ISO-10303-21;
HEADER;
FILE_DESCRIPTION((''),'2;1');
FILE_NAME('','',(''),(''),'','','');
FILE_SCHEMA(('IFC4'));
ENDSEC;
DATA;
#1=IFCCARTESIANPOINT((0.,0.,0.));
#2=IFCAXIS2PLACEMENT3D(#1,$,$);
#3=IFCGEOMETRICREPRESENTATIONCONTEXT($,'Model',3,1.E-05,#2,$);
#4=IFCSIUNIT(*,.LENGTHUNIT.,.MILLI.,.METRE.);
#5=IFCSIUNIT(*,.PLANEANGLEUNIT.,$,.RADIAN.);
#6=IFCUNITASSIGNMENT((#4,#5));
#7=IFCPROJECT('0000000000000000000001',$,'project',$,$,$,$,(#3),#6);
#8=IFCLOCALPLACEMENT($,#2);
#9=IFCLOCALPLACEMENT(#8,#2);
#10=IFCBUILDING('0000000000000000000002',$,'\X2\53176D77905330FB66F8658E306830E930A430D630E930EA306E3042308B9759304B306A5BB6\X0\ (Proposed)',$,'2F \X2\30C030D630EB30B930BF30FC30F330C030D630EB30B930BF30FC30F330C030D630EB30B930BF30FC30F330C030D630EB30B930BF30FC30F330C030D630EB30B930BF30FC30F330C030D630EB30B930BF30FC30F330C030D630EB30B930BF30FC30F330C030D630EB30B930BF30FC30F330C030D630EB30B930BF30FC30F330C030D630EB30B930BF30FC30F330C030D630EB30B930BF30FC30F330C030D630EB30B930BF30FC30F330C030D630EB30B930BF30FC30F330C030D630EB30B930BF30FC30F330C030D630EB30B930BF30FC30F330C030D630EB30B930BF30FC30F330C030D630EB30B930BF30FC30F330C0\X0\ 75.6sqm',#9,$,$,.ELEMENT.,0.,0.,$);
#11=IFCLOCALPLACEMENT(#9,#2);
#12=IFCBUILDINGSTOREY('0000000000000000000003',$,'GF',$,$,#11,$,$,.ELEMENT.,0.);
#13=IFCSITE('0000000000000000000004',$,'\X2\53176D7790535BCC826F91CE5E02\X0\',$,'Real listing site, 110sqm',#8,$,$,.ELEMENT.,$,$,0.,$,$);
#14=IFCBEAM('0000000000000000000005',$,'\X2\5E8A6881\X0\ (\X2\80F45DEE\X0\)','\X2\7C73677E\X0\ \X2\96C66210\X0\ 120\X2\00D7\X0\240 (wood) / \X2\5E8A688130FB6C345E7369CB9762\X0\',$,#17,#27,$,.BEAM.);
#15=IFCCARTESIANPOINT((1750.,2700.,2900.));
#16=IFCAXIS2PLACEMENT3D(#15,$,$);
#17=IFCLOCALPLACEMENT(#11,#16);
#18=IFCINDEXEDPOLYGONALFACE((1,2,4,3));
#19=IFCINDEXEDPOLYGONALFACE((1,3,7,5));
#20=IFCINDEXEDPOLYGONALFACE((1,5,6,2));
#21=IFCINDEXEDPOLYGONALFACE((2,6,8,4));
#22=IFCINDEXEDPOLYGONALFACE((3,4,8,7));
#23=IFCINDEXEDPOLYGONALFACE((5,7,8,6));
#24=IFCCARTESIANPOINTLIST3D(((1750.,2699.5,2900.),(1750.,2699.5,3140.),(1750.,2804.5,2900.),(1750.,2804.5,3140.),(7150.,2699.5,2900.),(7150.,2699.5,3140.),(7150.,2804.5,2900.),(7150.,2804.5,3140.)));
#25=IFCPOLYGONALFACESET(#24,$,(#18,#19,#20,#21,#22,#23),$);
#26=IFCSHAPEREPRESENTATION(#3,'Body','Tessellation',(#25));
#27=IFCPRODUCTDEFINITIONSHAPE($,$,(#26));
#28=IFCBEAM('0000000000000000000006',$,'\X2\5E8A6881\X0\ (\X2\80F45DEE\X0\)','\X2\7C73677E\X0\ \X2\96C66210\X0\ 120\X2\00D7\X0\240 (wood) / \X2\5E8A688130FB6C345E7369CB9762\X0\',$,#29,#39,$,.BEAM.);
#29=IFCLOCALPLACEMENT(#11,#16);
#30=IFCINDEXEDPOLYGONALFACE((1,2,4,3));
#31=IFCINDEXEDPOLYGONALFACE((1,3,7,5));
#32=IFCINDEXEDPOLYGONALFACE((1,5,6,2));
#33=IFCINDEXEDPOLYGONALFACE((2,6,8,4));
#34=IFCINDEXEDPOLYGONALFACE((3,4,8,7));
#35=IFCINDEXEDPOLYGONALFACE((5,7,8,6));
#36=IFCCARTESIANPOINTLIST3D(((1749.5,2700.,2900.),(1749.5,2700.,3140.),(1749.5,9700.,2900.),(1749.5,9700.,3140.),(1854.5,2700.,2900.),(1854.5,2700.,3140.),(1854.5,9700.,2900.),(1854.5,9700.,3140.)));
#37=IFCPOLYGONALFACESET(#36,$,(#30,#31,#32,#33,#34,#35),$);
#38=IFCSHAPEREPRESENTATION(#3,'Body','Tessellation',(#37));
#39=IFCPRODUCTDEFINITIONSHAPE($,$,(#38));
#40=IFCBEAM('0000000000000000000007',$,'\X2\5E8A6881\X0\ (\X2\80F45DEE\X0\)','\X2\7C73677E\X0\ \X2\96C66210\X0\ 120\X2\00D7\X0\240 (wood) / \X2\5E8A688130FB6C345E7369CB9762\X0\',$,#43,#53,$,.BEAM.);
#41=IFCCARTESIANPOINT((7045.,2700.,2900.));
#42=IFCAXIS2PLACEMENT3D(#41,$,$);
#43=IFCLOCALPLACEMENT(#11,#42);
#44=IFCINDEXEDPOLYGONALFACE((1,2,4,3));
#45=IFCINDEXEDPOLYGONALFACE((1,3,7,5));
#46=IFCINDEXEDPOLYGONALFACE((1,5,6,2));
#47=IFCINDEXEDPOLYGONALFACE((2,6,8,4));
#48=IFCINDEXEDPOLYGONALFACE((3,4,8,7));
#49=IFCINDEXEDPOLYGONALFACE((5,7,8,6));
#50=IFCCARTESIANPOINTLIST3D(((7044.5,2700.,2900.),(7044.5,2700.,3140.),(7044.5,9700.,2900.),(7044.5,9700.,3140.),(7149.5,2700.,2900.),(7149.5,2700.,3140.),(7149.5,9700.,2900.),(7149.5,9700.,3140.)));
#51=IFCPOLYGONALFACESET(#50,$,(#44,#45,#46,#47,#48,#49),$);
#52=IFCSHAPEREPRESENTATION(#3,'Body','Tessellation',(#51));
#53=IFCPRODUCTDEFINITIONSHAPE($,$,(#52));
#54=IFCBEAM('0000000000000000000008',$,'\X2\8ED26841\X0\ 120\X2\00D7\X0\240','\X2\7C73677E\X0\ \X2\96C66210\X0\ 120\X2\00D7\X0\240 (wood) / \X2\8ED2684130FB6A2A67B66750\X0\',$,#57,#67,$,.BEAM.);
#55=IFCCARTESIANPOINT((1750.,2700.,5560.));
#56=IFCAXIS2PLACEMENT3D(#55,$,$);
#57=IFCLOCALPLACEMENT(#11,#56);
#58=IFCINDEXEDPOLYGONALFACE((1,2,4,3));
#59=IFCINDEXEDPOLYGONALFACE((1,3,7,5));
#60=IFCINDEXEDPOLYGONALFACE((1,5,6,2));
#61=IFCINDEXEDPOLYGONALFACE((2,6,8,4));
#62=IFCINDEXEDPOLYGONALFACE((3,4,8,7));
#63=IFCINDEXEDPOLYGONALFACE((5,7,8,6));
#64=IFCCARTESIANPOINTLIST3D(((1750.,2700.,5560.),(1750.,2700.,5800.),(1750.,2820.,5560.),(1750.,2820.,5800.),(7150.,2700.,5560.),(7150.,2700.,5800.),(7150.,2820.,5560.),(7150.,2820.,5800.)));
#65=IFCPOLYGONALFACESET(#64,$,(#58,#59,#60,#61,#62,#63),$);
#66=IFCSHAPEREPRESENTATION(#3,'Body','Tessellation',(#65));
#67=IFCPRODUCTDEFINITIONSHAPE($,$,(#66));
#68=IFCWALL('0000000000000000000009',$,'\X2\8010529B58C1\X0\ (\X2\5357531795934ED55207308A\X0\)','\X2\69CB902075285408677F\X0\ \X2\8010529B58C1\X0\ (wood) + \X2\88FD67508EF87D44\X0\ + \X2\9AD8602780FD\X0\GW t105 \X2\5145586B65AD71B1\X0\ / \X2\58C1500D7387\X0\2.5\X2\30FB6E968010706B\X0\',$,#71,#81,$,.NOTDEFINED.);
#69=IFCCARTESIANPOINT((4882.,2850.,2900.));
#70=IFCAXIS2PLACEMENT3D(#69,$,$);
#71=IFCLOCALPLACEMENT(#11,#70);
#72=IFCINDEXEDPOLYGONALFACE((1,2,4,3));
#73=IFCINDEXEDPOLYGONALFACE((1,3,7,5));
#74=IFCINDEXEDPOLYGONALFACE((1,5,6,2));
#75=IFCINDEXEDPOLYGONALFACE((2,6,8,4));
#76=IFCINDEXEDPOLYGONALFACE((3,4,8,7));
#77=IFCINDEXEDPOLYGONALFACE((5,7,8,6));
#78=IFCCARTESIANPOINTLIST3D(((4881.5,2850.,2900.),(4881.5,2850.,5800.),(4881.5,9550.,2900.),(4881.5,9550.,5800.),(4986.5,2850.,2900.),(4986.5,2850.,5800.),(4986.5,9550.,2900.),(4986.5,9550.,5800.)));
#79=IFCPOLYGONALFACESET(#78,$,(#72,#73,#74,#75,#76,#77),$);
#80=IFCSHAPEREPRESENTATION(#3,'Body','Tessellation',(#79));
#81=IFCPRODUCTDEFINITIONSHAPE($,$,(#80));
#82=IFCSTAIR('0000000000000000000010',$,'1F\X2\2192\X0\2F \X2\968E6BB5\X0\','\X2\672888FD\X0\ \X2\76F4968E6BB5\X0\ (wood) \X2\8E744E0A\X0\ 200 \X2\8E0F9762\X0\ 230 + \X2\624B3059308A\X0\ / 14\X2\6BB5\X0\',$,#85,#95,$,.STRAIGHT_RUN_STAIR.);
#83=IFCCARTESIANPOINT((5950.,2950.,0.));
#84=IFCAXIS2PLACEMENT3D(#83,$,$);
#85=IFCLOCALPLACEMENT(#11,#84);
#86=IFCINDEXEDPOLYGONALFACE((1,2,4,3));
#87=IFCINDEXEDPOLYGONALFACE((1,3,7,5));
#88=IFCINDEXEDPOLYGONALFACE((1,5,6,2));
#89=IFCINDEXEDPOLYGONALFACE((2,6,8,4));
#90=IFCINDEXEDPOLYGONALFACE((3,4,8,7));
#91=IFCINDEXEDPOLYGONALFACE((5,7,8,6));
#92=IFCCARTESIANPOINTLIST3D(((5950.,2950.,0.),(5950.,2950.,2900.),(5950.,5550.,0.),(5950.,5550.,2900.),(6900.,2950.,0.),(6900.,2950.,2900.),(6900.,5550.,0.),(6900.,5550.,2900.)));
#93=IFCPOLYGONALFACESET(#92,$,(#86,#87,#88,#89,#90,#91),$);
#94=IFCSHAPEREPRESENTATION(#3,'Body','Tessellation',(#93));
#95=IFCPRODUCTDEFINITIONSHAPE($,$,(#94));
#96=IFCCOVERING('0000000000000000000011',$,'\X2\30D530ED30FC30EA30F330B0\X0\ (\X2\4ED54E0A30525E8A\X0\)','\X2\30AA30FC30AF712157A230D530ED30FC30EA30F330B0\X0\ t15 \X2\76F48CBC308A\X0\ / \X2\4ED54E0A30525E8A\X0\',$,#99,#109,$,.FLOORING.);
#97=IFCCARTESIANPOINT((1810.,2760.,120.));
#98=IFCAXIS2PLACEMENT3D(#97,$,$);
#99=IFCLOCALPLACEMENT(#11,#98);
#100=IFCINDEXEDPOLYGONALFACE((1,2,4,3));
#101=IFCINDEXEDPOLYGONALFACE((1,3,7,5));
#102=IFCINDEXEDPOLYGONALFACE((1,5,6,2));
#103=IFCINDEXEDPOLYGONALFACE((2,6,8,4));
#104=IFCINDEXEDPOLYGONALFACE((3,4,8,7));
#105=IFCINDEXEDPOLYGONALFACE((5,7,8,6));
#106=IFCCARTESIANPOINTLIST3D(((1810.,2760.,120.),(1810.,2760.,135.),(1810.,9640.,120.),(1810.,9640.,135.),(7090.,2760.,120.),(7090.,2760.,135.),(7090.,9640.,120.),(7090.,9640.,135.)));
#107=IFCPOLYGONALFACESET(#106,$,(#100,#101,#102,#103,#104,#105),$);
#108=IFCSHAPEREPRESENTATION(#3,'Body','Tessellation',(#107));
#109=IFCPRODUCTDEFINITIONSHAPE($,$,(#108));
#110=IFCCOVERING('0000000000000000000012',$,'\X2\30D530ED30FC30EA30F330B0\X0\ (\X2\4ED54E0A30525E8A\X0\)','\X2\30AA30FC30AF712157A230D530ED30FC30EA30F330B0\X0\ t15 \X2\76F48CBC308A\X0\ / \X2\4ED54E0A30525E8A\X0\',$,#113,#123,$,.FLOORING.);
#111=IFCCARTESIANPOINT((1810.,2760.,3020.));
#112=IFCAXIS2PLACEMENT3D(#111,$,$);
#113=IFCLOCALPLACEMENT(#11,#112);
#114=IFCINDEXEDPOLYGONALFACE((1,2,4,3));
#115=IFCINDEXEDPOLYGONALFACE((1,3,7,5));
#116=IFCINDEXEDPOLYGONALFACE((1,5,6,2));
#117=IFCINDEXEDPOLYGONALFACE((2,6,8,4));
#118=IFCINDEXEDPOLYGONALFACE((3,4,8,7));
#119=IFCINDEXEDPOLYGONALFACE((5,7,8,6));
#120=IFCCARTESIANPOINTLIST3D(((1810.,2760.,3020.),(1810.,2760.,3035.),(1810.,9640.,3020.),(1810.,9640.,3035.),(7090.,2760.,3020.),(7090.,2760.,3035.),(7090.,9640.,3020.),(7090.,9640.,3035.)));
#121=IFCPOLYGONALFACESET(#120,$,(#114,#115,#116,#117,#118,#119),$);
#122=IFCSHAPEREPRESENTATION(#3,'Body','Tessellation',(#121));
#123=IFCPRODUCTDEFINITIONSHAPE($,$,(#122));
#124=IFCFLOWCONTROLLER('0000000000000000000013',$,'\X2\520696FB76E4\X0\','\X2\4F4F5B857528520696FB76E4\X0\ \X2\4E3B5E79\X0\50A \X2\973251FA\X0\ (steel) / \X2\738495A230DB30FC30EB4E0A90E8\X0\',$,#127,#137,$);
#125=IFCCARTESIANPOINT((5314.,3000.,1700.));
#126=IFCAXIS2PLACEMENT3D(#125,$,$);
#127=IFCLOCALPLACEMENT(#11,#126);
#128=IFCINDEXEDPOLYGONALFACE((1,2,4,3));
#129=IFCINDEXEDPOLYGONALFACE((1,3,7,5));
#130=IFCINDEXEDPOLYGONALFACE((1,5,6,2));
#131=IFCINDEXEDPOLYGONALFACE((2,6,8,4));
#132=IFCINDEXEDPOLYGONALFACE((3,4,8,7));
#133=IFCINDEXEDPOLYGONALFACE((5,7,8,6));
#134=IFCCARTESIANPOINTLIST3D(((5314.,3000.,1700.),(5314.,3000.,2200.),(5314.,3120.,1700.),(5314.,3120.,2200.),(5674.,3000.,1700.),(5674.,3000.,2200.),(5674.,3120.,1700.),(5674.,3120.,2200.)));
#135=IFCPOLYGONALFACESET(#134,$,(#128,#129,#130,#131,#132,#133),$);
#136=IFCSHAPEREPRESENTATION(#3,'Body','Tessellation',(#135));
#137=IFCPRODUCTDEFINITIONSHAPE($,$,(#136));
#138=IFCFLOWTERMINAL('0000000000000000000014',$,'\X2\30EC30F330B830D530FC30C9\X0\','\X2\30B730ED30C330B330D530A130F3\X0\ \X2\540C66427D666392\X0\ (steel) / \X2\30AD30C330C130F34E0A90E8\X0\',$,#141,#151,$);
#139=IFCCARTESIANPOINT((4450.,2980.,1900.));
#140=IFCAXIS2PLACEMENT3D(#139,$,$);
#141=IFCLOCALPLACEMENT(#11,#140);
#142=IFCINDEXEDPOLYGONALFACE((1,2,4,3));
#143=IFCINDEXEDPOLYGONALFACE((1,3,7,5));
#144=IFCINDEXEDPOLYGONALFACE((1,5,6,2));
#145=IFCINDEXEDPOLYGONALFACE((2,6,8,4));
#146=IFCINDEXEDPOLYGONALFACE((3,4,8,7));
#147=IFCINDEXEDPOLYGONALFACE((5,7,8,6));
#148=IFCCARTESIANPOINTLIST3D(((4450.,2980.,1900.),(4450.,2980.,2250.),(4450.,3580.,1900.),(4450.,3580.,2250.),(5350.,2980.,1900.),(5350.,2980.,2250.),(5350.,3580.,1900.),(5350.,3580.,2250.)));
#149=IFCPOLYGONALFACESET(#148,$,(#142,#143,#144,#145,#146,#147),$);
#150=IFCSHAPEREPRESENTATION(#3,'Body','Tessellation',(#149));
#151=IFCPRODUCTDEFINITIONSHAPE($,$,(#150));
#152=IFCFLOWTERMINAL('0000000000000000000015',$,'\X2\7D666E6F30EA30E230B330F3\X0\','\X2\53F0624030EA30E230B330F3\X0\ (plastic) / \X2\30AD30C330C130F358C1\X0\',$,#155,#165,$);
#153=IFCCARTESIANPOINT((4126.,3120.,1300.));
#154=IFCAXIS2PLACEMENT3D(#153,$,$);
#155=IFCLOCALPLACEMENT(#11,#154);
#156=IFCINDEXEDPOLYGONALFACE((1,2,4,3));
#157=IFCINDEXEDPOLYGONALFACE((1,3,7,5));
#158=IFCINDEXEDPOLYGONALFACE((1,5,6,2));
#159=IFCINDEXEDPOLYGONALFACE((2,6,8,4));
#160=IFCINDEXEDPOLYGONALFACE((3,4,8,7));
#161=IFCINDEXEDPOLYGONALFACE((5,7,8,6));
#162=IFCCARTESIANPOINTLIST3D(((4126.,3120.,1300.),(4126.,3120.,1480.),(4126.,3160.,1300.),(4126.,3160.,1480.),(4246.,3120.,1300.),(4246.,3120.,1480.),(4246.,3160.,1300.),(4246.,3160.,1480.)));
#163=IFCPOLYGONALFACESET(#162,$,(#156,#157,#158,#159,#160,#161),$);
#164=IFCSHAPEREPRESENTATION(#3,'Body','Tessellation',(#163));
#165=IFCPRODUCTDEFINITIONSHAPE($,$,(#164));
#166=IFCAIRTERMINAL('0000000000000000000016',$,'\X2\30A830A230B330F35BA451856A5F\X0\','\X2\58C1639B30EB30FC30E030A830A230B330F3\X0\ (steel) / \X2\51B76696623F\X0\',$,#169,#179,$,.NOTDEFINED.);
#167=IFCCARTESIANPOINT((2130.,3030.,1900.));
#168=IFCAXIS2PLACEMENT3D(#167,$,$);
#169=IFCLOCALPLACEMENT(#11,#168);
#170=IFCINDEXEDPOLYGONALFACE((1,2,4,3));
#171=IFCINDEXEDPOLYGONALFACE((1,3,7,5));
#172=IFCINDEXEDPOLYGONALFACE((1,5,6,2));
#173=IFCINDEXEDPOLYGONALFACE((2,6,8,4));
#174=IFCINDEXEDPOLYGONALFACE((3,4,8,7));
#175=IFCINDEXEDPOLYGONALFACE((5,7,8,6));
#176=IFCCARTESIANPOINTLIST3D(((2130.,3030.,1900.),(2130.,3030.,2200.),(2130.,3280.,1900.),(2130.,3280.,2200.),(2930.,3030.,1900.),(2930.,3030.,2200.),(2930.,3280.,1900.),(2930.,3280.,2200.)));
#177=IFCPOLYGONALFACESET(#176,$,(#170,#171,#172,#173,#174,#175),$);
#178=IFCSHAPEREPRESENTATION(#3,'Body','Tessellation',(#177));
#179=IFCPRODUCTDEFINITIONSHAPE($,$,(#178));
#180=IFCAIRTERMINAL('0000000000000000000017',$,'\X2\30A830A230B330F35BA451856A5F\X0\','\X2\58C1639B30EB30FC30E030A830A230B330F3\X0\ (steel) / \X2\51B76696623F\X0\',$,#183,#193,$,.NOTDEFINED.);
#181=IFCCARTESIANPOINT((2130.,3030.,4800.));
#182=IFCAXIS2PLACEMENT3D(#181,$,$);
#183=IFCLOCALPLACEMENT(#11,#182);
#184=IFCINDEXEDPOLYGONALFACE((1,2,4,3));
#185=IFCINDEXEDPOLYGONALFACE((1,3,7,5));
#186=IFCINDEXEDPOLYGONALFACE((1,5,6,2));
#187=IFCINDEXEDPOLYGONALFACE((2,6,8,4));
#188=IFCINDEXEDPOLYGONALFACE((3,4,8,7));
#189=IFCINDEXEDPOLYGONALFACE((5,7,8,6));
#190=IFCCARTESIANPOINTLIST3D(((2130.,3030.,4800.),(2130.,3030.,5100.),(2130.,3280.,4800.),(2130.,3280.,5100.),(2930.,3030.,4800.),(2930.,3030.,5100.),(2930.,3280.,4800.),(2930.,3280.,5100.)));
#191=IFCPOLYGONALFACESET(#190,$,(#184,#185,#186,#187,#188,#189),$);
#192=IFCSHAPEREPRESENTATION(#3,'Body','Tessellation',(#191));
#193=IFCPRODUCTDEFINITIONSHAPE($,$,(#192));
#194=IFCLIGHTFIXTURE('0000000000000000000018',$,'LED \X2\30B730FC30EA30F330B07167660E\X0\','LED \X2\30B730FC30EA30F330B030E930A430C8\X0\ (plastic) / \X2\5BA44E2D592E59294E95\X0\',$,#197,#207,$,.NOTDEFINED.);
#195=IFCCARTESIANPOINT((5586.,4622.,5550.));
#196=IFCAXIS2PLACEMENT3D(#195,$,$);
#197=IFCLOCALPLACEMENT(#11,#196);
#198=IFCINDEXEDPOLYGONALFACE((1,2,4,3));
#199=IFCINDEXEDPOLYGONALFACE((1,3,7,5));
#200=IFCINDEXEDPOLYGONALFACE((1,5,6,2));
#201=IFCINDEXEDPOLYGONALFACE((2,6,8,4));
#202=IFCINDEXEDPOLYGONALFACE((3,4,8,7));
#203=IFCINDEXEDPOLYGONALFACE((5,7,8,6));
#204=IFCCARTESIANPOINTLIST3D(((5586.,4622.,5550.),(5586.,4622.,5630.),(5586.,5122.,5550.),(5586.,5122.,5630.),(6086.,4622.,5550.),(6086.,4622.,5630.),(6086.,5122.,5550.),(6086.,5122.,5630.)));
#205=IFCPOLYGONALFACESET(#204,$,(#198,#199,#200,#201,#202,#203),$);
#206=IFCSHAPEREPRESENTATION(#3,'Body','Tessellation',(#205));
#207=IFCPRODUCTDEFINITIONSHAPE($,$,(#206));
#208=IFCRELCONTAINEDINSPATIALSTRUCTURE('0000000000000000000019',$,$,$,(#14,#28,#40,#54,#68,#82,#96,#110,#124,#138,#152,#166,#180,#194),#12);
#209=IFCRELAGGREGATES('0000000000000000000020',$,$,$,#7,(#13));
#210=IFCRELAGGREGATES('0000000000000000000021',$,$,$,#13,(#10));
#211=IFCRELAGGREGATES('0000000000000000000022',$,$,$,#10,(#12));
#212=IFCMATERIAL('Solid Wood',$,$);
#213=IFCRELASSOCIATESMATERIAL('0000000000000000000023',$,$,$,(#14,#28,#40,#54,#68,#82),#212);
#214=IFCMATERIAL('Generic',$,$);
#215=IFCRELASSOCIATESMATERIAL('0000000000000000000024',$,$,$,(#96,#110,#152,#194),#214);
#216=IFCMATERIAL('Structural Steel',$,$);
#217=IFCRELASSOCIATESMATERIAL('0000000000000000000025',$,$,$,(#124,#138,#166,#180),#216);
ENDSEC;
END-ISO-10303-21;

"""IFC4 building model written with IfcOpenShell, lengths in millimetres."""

from ifc_helpers import new_model, si_unit, frame, frame_2d, origin, place, context, project, spatial, rectangle, extrude, material, element, save


model = new_model("IFC4")

# Units and contexts
model_context = context("Model", 3, precision=1e-05, world=origin())
ifc_project = project(units=[si_unit("LENGTHUNIT", "METRE", prefix="MILLI"), si_unit("PLANEANGLEUNIT", "RADIAN")], contexts=[model_context])

# Site, building, storey
site_placement = place(None, origin())
site = spatial("IfcSite", under=ifc_project, at=site_placement, Name="北海道富良野市", ObjectType="Real listing site, 110sqm", CompositionType="ELEMENT", RefElevation=0.0)
building_placement = place(site_placement, origin())
building = spatial("IfcBuilding", under=site, at=building_placement, Name="北海道・書斎とライブラリのある静かな家 (Proposed)", ObjectType="2F ダブルスターンダブルスターンダブルスターンダブルスターンダブルスターンダブルスターンダブルスターンダブルスターンダブルスターンダブルスターンダブルスターンダブルスターンダブルスターンダブルスターンダブルスターンダブルスターンダブルスターンダ 75.6sqm", CompositionType="ELEMENT", ElevationOfRefHeight=0.0, ElevationOfTerrain=0.0)
storey_placement = place(building_placement, origin())
storey = spatial("IfcBuildingStorey", under=building, at=storey_placement, Name="GF", CompositionType="ELEMENT", Elevation=0.0)

# Shared definitions
ifc_material_1 = material(Name="Solid Wood")

# Beams
beam_1_placement = place(storey_placement, frame((1750.0, 2700.0, 2900.0)))
element("IfcBeam", 1, at=beam_1_placement, inside=storey, material=ifc_material_1, Name="床梁 (胴差)", Description="米松 集成 120×240 (wood) / 床梁・水平構面", PredefinedType="BEAM", context=model_context, shape_type="SweptSolid", body=[
    extrude(rectangle(XDim=5400.0, YDim=105.0, at=frame_2d((2700.0, 52.0))), frame((1750.0, 2700.0, 2900.0)), (0.0, 0.0, 1.0), 240.0),
])
beam_2_placement = place(storey_placement, frame((1750.0, 2700.0, 2900.0)))
element("IfcBeam", 2, at=beam_2_placement, inside=storey, material=ifc_material_1, Name="床梁 (胴差)", Description="米松 集成 120×240 (wood) / 床梁・水平構面", PredefinedType="BEAM", context=model_context, shape_type="SweptSolid", body=[
    extrude(rectangle(XDim=105.0, YDim=7000.0, at=frame_2d((52.0, 3500.0))), frame((1750.0, 2700.0, 2900.0)), (0.0, 0.0, 1.0), 240.0),
])
beam_3_placement = place(storey_placement, frame((7045.0, 2700.0, 2900.0)))
element("IfcBeam", 3, at=beam_3_placement, inside=storey, material=ifc_material_1, Name="床梁 (胴差)", Description="米松 集成 120×240 (wood) / 床梁・水平構面", PredefinedType="BEAM", context=model_context, shape_type="SweptSolid", body=[
    extrude(rectangle(XDim=105.0, YDim=7000.0, at=frame_2d((52.0, 3500.0))), frame((7045.0, 2700.0, 2900.0)), (0.0, 0.0, 1.0), 240.0),
])
beam_4_placement = place(storey_placement, frame((1750.0, 2700.0, 5560.0)))
element("IfcBeam", 4, at=beam_4_placement, inside=storey, material=ifc_material_1, Name="軒桁 120×240", Description="米松 集成 120×240 (wood) / 軒桁・横架材", PredefinedType="BEAM", context=model_context, shape_type="SweptSolid", body=[
    extrude(rectangle(XDim=5400.0, YDim=120.0, at=frame_2d((2700.0, 60.0))), frame((1750.0, 2700.0, 5560.0)), (0.0, 0.0, 1.0), 240.0),
])

# Wall
wall_1_placement = place(storey_placement, frame((4882.0, 2850.0, 2900.0)))
element("IfcWall", 5, at=wall_1_placement, inside=storey, material=ifc_material_1, Name="耐力壁 (南北間仕切り)", Description="構造用合板 耐力壁 (wood) + 製材軸組 + 高性能GW t105 充填断熱 / 壁倍率2.5・準耐火", PredefinedType="NOTDEFINED", context=model_context, shape_type="SweptSolid", body=[
    extrude(rectangle(XDim=105.0, YDim=6700.0, at=frame_2d((52.0, 3350.0))), frame((4882.0, 2850.0, 2900.0)), (0.0, 0.0, 1.0), 2900.0),
])

# Stair
stair_placement = place(storey_placement, frame((5950.0, 2950.0, 0.0)))
element("IfcStair", 6, at=stair_placement, inside=storey, material=ifc_material_1, Name="1F→2F 階段", Description="木製 直階段 (wood) 蹴上 200 踏面 230 + 手すり / 14段", PredefinedType="STRAIGHT_RUN_STAIR", context=model_context, shape_type="SweptSolid", body=[
    extrude(rectangle(XDim=950.0, YDim=2600.0, at=frame_2d((475.0, 1300.0))), frame((5950.0, 2950.0, 0.0)), (0.0, 0.0, 1.0), 2900.0),
])

# Coverings
ifc_material_2 = material(Name="Generic")
covering_1_placement = place(storey_placement, frame((1810.0, 2760.0, 120.0)))
element("IfcCovering", 7, at=covering_1_placement, inside=storey, material=ifc_material_2, Name="フローリング (仕上げ床)", Description="オーク無垢フローリング t15 直貼り / 仕上げ床", PredefinedType="FLOORING", context=model_context, shape_type="SweptSolid", body=[
    extrude(rectangle(XDim=5280.0, YDim=6880.0, at=frame_2d((2640.0, 3440.0))), frame((1810.0, 2760.0, 120.0)), (0.0, 0.0, 1.0), 15.0),
])
covering_2_placement = place(storey_placement, frame((1810.0, 2760.0, 3020.0)))
element("IfcCovering", 8, at=covering_2_placement, inside=storey, material=ifc_material_2, Name="フローリング (仕上げ床)", Description="オーク無垢フローリング t15 直貼り / 仕上げ床", PredefinedType="FLOORING", context=model_context, shape_type="SweptSolid", body=[
    extrude(rectangle(XDim=5280.0, YDim=6880.0, at=frame_2d((2640.0, 3440.0))), frame((1810.0, 2760.0, 3020.0)), (0.0, 0.0, 1.0), 15.0),
])

# Flow controller
ifc_material_3 = material(Name="Structural Steel")
flow_controller_placement = place(storey_placement, frame((5314.0, 3000.0, 1700.0)))
element("IfcFlowController", 9, at=flow_controller_placement, inside=storey, material=ifc_material_3, Name="分電盤", Description="住宅用分電盤 主幹50A 露出 (steel) / 玄関ホール上部", context=model_context, shape_type="SweptSolid", body=[
    extrude(rectangle(XDim=360.0, YDim=120.0, at=frame_2d((180.0, 60.0))), frame((5314.0, 3000.0, 1700.0)), (0.0, 0.0, 1.0), 500.0),
])

# Flow terminals
flow_terminal_1_placement = place(storey_placement, frame((4450.0, 2980.0, 1900.0)))
element("IfcFlowTerminal", 10, at=flow_terminal_1_placement, inside=storey, material=ifc_material_3, Name="レンジフード", Description="シロッコファン 同時給排 (steel) / キッチン上部", context=model_context, shape_type="SweptSolid", body=[
    extrude(rectangle(XDim=900.0, YDim=600.0, at=frame_2d((450.0, 300.0))), frame((4450.0, 2980.0, 1900.0)), (0.0, 0.0, 1.0), 350.0),
])
flow_terminal_2_placement = place(storey_placement, frame((4126.0, 3120.0, 1300.0)))
element("IfcFlowTerminal", 11, at=flow_terminal_2_placement, inside=storey, material=ifc_material_2, Name="給湯リモコン", Description="台所リモコン (plastic) / キッチン壁", context=model_context, shape_type="SweptSolid", body=[
    extrude(rectangle(XDim=120.0, YDim=40.0, at=frame_2d((60.0, 20.0))), frame((4126.0, 3120.0, 1300.0)), (0.0, 0.0, 1.0), 180.0),
])

# Air terminals
air_terminal_1_placement = place(storey_placement, frame((2130.0, 3030.0, 1900.0)))
element("IfcAirTerminal", 12, at=air_terminal_1_placement, inside=storey, material=ifc_material_3, Name="エアコン室内機", Description="壁掛ルームエアコン (steel) / 冷暖房", PredefinedType="NOTDEFINED", context=model_context, shape_type="SweptSolid", body=[
    extrude(rectangle(XDim=800.0, YDim=250.0, at=frame_2d((400.0, 125.0))), frame((2130.0, 3030.0, 1900.0)), (0.0, 0.0, 1.0), 300.0),
])
air_terminal_2_placement = place(storey_placement, frame((2130.0, 3030.0, 4800.0)))
element("IfcAirTerminal", 13, at=air_terminal_2_placement, inside=storey, material=ifc_material_3, Name="エアコン室内機", Description="壁掛ルームエアコン (steel) / 冷暖房", PredefinedType="NOTDEFINED", context=model_context, shape_type="SweptSolid", body=[
    extrude(rectangle(XDim=800.0, YDim=250.0, at=frame_2d((400.0, 125.0))), frame((2130.0, 3030.0, 4800.0)), (0.0, 0.0, 1.0), 300.0),
])

# Light fixture
light_fixture_placement = place(storey_placement, frame((5586.0, 4622.0, 5550.0)))
element("IfcLightFixture", 14, at=light_fixture_placement, inside=storey, material=ifc_material_2, Name="LED シーリング照明", Description="LED シーリングライト (plastic) / 室中央天井", PredefinedType="NOTDEFINED", context=model_context, shape_type="SweptSolid", body=[
    extrude(rectangle(XDim=500.0, YDim=500.0, at=frame_2d((250.0, 250.0))), frame((5586.0, 4622.0, 5550.0)), (0.0, 0.0, 1.0), 80.0),
])

save(model, "model.ifc")
